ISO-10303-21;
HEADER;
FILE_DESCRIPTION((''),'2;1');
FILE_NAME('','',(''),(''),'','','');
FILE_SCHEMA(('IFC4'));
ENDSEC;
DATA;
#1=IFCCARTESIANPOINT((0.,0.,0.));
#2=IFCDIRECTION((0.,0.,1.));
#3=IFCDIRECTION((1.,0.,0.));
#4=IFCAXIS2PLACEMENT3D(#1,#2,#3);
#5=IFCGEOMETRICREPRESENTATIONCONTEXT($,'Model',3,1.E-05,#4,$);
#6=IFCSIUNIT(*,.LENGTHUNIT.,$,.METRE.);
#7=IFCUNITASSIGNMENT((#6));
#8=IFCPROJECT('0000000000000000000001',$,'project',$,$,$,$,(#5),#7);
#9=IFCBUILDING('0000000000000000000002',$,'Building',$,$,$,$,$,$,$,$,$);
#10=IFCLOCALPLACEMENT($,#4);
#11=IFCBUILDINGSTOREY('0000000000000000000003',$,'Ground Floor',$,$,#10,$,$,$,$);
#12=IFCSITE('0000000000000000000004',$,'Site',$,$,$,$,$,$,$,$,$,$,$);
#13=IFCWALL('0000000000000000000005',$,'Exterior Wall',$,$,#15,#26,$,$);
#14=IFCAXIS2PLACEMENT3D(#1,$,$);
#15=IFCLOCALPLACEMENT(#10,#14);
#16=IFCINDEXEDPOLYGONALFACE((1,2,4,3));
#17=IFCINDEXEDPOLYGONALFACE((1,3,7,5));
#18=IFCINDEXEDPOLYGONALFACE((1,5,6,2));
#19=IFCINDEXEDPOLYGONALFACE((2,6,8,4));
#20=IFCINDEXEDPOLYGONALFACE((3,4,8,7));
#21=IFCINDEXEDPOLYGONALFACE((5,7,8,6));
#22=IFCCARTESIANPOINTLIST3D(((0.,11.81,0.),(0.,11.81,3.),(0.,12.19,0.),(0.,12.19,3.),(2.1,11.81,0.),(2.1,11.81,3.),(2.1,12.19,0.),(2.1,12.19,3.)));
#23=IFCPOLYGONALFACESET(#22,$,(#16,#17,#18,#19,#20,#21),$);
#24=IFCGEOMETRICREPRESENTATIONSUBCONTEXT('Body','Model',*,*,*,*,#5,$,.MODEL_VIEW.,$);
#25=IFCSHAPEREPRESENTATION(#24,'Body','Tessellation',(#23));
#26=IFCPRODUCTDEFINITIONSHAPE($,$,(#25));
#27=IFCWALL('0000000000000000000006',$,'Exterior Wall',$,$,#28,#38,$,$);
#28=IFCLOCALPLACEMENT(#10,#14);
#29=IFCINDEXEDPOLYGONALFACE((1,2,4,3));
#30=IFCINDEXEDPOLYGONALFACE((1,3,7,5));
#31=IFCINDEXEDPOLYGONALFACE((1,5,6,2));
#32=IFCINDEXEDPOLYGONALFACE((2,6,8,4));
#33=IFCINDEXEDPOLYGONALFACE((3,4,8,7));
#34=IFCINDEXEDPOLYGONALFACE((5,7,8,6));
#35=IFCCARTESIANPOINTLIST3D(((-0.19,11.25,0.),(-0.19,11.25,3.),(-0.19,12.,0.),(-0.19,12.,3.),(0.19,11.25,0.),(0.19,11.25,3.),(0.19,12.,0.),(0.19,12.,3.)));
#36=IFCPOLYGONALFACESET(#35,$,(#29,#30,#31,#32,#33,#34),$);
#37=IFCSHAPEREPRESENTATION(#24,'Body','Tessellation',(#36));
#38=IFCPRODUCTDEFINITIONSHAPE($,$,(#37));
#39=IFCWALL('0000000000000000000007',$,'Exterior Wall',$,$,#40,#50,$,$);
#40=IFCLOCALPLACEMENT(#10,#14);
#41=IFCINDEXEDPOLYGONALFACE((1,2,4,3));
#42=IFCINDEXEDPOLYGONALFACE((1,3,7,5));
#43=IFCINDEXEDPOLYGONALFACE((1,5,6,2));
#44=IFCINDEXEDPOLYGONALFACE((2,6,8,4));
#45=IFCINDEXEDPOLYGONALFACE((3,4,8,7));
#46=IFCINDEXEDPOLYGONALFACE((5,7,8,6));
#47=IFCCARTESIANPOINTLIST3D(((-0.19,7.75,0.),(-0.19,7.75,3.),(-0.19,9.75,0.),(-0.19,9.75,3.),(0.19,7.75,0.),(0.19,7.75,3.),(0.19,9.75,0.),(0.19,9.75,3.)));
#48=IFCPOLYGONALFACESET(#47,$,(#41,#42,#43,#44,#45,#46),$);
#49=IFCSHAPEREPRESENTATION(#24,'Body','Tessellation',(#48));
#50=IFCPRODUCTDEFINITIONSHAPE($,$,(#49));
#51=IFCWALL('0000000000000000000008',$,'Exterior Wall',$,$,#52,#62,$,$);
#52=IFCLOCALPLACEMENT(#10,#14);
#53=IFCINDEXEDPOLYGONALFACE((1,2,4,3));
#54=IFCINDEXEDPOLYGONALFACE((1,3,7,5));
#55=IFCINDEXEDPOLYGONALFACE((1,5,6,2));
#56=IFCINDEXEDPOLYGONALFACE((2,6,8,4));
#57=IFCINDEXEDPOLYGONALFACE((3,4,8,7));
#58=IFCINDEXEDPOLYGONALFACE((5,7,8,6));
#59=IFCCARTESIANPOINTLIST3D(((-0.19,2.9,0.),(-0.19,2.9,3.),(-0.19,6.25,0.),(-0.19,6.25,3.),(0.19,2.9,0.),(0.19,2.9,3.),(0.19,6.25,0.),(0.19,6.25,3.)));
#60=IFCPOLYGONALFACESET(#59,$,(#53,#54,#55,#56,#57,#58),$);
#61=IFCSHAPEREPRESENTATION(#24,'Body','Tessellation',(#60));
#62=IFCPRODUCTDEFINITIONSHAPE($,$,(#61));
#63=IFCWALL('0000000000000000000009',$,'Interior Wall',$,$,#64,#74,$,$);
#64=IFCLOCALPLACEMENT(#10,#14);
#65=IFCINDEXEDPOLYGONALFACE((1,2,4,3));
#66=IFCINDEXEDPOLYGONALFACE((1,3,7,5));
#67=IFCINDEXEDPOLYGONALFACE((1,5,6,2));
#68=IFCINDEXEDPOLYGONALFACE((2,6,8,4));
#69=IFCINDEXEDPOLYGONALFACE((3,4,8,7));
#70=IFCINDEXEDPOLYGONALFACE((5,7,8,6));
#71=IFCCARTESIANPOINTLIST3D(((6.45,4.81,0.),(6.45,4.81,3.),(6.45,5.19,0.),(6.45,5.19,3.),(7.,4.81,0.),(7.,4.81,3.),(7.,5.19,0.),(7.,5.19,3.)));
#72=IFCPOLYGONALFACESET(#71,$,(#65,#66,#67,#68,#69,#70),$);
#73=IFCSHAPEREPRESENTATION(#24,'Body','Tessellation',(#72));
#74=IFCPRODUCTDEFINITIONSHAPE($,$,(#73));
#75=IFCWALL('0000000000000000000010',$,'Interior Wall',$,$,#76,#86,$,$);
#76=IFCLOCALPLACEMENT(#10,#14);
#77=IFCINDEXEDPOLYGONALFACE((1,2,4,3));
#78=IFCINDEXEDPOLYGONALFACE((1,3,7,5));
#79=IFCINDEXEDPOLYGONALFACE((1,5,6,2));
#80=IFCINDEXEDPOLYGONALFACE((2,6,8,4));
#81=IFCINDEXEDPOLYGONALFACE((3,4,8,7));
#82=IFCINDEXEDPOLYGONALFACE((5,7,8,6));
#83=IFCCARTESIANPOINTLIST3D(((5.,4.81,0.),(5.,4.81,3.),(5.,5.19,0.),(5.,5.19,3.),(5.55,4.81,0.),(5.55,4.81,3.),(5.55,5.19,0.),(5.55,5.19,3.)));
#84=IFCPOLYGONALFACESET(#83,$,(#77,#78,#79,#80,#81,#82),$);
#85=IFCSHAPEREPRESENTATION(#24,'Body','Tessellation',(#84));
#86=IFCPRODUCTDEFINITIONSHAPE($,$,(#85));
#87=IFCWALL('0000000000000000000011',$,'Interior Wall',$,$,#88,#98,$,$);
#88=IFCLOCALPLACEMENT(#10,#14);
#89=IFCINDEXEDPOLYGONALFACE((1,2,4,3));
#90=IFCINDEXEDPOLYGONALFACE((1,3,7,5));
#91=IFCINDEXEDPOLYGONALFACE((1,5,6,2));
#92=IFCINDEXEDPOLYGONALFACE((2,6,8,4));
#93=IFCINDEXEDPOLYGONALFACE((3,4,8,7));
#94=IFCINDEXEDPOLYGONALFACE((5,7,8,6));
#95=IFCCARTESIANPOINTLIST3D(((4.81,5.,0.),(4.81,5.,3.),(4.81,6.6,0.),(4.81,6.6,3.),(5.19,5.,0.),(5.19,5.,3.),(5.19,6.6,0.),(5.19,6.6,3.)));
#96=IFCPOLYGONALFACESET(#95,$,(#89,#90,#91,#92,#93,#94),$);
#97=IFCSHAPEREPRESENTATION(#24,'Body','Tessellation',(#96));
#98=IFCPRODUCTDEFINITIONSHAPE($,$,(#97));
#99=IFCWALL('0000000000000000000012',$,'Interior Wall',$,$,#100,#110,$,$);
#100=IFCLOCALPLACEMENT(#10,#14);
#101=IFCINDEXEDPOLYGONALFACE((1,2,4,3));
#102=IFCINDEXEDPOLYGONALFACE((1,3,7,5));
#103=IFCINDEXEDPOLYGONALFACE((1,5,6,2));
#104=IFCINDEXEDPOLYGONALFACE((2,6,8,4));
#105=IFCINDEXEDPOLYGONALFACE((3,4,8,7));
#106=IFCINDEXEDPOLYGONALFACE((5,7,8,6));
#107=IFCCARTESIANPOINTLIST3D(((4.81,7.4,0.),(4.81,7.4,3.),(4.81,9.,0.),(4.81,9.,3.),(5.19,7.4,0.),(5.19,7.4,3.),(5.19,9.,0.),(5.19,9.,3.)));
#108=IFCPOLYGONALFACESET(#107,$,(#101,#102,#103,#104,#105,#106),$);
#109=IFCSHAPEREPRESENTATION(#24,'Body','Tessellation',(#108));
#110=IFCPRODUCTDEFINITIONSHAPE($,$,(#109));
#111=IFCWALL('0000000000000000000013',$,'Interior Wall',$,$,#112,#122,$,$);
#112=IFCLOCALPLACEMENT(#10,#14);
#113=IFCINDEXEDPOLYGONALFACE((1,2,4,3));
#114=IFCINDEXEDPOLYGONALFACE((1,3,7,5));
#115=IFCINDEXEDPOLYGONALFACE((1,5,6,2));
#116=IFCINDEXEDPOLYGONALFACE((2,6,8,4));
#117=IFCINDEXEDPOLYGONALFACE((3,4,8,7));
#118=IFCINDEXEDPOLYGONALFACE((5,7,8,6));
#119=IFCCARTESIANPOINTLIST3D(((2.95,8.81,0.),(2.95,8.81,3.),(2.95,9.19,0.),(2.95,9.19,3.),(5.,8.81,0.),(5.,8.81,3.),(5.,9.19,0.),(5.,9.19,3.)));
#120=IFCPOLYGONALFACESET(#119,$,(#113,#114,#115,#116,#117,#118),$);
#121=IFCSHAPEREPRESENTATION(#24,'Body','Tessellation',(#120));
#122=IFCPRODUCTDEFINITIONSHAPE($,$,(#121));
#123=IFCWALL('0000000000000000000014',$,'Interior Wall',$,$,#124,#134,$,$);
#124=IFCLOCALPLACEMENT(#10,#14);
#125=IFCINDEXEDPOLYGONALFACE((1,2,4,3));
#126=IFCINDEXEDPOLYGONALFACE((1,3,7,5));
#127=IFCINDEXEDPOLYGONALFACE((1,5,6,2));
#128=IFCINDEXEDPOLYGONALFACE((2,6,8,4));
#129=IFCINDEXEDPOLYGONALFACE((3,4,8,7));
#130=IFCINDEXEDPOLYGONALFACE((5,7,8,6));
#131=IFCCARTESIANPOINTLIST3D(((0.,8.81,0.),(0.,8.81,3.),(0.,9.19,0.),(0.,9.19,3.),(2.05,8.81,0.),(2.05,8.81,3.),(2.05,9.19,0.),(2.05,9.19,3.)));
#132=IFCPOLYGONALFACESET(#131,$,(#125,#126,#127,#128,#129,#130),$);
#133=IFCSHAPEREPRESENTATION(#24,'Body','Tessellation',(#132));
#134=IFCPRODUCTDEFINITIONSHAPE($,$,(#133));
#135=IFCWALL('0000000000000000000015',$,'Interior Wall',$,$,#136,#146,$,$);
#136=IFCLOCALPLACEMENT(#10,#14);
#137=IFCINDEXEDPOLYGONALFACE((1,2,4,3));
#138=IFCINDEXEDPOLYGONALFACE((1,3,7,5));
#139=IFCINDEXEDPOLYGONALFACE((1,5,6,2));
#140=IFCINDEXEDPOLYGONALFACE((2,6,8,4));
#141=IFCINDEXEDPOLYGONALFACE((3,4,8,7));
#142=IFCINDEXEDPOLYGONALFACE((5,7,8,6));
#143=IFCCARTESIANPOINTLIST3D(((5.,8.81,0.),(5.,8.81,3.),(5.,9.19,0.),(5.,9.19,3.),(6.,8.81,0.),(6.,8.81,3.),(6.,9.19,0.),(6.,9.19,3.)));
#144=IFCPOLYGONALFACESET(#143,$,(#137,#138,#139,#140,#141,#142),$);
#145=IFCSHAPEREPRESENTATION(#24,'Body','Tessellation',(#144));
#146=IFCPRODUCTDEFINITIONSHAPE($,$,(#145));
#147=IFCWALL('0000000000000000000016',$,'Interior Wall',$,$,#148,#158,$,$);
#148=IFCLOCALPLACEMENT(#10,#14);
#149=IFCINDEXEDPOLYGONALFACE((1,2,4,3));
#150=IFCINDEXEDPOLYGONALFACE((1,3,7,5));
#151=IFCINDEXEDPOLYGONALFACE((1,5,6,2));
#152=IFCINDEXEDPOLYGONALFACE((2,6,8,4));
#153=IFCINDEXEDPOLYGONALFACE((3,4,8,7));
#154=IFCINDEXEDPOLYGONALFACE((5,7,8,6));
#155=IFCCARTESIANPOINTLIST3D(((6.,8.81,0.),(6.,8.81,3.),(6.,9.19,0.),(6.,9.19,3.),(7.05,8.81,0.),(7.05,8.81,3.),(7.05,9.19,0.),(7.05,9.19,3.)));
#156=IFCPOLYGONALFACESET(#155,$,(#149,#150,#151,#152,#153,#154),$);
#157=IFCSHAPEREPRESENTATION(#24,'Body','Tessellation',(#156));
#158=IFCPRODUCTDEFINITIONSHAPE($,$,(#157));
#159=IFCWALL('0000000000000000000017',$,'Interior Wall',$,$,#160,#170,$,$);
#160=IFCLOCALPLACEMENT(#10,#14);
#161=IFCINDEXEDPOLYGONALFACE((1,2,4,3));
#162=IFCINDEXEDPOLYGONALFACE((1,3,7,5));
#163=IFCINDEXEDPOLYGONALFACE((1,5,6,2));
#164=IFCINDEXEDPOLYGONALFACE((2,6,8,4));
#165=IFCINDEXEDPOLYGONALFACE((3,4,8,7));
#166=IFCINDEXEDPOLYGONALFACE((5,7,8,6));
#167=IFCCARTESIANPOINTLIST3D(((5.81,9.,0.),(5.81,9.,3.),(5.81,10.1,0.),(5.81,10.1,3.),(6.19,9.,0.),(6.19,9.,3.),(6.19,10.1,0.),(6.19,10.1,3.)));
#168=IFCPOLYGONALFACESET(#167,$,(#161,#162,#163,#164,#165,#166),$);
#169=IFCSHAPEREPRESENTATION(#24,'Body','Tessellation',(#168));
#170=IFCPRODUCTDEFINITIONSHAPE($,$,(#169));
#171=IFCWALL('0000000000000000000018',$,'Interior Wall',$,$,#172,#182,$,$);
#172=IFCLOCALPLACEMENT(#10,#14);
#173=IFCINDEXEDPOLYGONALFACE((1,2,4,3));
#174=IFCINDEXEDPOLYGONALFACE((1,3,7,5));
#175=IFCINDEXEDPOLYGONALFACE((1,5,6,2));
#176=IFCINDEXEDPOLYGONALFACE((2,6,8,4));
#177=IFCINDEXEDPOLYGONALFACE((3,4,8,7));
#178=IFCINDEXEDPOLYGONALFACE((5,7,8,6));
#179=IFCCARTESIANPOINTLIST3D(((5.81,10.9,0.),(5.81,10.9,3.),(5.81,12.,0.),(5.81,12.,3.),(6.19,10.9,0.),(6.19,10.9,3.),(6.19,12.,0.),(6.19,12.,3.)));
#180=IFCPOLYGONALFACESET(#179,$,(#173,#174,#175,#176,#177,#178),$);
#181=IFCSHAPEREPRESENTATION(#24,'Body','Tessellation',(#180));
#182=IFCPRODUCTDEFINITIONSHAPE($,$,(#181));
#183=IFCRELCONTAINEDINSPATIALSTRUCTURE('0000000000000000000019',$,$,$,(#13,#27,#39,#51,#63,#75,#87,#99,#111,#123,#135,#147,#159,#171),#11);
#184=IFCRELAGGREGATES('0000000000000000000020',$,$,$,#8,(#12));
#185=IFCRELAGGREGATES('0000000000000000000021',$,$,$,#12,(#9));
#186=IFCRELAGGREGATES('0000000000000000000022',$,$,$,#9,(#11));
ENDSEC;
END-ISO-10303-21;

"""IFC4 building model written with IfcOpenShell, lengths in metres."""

from ifc_helpers import new_model, si_unit, frame, origin_with_axes, place, context, subcontext, project, spatial, indexed_curve, outline, extrude, element, save


model = new_model("IFC4")

# Units and contexts
model_context = context("Model", 3, precision=1e-05, world=origin_with_axes())
body_context = subcontext(model_context, "Body", "Model", "MODEL_VIEW")
ifc_project = project(units=[si_unit("LENGTHUNIT", "METRE")], contexts=[model_context])

# Site, building, storey
site = spatial("IfcSite", under=ifc_project, Name="Site")
building = spatial("IfcBuilding", under=site, Name="Building")
storey_placement = place(None, origin_with_axes())
storey = spatial("IfcBuildingStorey", under=building, at=storey_placement, Name="Ground Floor")

# Walls
wall_1_placement = place(storey_placement, frame((2.1, 12.0, 0.0), z_axis=(0.0, 0.0, 1.0), x_axis=(-1.0, 0.0, 0.0)))
element("IfcWall", 1, at=wall_1_placement, inside=storey, Name="Exterior Wall", context=body_context, shape_type="SweptSolid", body=[
    extrude(outline(indexed_curve([(0.0, 0.0), (0.0, 0.38), (2.1, 0.38), (2.1, 0.0), (0.0, 0.0)], self_intersect=False)), frame((0.0, -0.19, 0.0), z_axis=(0.0, 0.0, 1.0), x_axis=(1.0, 0.0, 0.0)), (0.0, 0.0, 1.0), 3.0),
])
wall_2_placement = place(storey_placement, frame((0.0, 12.0, 0.0), z_axis=(0.0, 0.0, 1.0), x_axis=(0.0, -1.0, 0.0)))
element("IfcWall", 2, at=wall_2_placement, inside=storey, Name="Exterior Wall", context=body_context, shape_type="SweptSolid", body=[
    extrude(outline(indexed_curve([(0.0, 0.0), (0.0, 0.38), (0.75, 0.38), (0.75, 0.0), (0.0, 0.0)], self_intersect=False)), frame((0.0, -0.19, 0.0), z_axis=(0.0, 0.0, 1.0), x_axis=(1.0, 0.0, 0.0)), (0.0, 0.0, 1.0), 3.0),
])
wall_3_placement = place(storey_placement, frame((0.0, 9.75, 0.0), z_axis=(0.0, 0.0, 1.0), x_axis=(0.0, -1.0, 0.0)))
element("IfcWall", 3, at=wall_3_placement, inside=storey, Name="Exterior Wall", context=body_context, shape_type="SweptSolid", body=[
    extrude(outline(indexed_curve([(0.0, 0.0), (0.0, 0.38), (2.0, 0.38), (2.0, 0.0), (0.0, 0.0)], self_intersect=False)), frame((0.0, -0.19, 0.0), z_axis=(0.0, 0.0, 1.0), x_axis=(1.0, 0.0, 0.0)), (0.0, 0.0, 1.0), 3.0),
])
wall_4_placement = place(storey_placement, frame((0.0, 6.25, 0.0), z_axis=(0.0, 0.0, 1.0), x_axis=(0.0, -1.0, 0.0)))
element("IfcWall", 4, at=wall_4_placement, inside=storey, Name="Exterior Wall", context=body_context, shape_type="SweptSolid", body=[
    extrude(outline(indexed_curve([(0.0, 0.0), (0.0, 0.38), (3.35, 0.38), (3.35, 0.0), (0.0, 0.0)], self_intersect=False)), frame((0.0, -0.19, 0.0), z_axis=(0.0, 0.0, 1.0), x_axis=(1.0, 0.0, 0.0)), (0.0, 0.0, 1.0), 3.0),
])
for number, where, z_axis, x_axis, name in (
    (5, (7.0, 5.0, 0.0), (0.0, 0.0, 1.0), (-1.0, 0.0, 0.0), "Interior Wall"),
    (6, (5.55, 5.0, 0.0), (0.0, 0.0, 1.0), (-1.0, 0.0, 0.0), "Interior Wall"),
):
    element("IfcWall", number, at=place(storey_placement, frame(where, z_axis=z_axis, x_axis=x_axis)), inside=storey, Name=name, context=body_context, shape_type="SweptSolid", body=[
        extrude(outline(indexed_curve([(0.0, 0.0), (0.0, 0.38), (0.55, 0.38), (0.55, 0.0), (0.0, 0.0)], self_intersect=False)), frame((0.0, -0.19, 0.0), z_axis=(0.0, 0.0, 1.0), x_axis=(1.0, 0.0, 0.0)), (0.0, 0.0, 1.0), 3.0),
    ])
for number, where, z_axis, x_axis, name in (
    (7, (5.0, 5.0, 0.0), (0.0, 0.0, 1.0), (0.0, 1.0, 0.0), "Interior Wall"),
    (8, (5.0, 7.4, 0.0), (0.0, 0.0, 1.0), (0.0, 1.0, 0.0), "Interior Wall"),
):
    element("IfcWall", number, at=place(storey_placement, frame(where, z_axis=z_axis, x_axis=x_axis)), inside=storey, Name=name, context=body_context, shape_type="SweptSolid", body=[
        extrude(outline(indexed_curve([(0.0, 0.0), (0.0, 0.38), (1.6, 0.38), (1.6, 0.0), (0.0, 0.0)], self_intersect=False)), frame((0.0, -0.19, 0.0), z_axis=(0.0, 0.0, 1.0), x_axis=(1.0, 0.0, 0.0)), (0.0, 0.0, 1.0), 3.0),
    ])
for number, where, z_axis, x_axis, name in (
    (9, (5.0, 9.0, 0.0), (0.0, 0.0, 1.0), (-1.0, 0.0, 0.0), "Interior Wall"),
    (10, (2.05, 9.0, 0.0), (0.0, 0.0, 1.0), (-1.0, 0.0, 0.0), "Interior Wall"),
):
    element("IfcWall", number, at=place(storey_placement, frame(where, z_axis=z_axis, x_axis=x_axis)), inside=storey, Name=name, context=body_context, shape_type="SweptSolid", body=[
        extrude(outline(indexed_curve([(0.0, 0.0), (0.0, 0.38), (2.05, 0.38), (2.05, 0.0), (0.0, 0.0)], self_intersect=False)), frame((0.0, -0.19, 0.0), z_axis=(0.0, 0.0, 1.0), x_axis=(1.0, 0.0, 0.0)), (0.0, 0.0, 1.0), 3.0),
    ])
wall_5_placement = place(storey_placement, frame((6.0, 9.0, 0.0), z_axis=(0.0, 0.0, 1.0), x_axis=(-1.0, 0.0, 0.0)))
element("IfcWall", 11, at=wall_5_placement, inside=storey, Name="Interior Wall", context=body_context, shape_type="SweptSolid", body=[
    extrude(outline(indexed_curve([(0.0, 0.0), (0.0, 0.38), (1.0, 0.38), (1.0, 0.0), (0.0, 0.0)], self_intersect=False)), frame((0.0, -0.19, 0.0), z_axis=(0.0, 0.0, 1.0), x_axis=(1.0, 0.0, 0.0)), (0.0, 0.0, 1.0), 3.0),
])
wall_6_placement = place(storey_placement, frame((7.05, 9.0, 0.0), z_axis=(0.0, 0.0, 1.0), x_axis=(-1.0, 0.0, 0.0)))
element("IfcWall", 12, at=wall_6_placement, inside=storey, Name="Interior Wall", context=body_context, shape_type="SweptSolid", body=[
    extrude(outline(indexed_curve([(0.0, 0.0), (0.0, 0.38), (1.05, 0.38), (1.05, 0.0), (0.0, 0.0)], self_intersect=False)), frame((0.0, -0.19, 0.0), z_axis=(0.0, 0.0, 1.0), x_axis=(1.0, 0.0, 0.0)), (0.0, 0.0, 1.0), 3.0),
])
for number, where, z_axis, x_axis, name in (
    (13, (6.0, 9.0, 0.0), (0.0, 0.0, 1.0), (0.0, 1.0, 0.0), "Interior Wall"),
    (14, (6.0, 10.9, 0.0), (0.0, 0.0, 1.0), (0.0, 1.0, 0.0), "Interior Wall"),
):
    element("IfcWall", number, at=place(storey_placement, frame(where, z_axis=z_axis, x_axis=x_axis)), inside=storey, Name=name, context=body_context, shape_type="SweptSolid", body=[
        extrude(outline(indexed_curve([(0.0, 0.0), (0.0, 0.38), (1.1, 0.38), (1.1, 0.0), (0.0, 0.0)], self_intersect=False)), frame((0.0, -0.19, 0.0), z_axis=(0.0, 0.0, 1.0), x_axis=(1.0, 0.0, 0.0)), (0.0, 0.0, 1.0), 3.0),
    ])

save(model, "model.ifc")
